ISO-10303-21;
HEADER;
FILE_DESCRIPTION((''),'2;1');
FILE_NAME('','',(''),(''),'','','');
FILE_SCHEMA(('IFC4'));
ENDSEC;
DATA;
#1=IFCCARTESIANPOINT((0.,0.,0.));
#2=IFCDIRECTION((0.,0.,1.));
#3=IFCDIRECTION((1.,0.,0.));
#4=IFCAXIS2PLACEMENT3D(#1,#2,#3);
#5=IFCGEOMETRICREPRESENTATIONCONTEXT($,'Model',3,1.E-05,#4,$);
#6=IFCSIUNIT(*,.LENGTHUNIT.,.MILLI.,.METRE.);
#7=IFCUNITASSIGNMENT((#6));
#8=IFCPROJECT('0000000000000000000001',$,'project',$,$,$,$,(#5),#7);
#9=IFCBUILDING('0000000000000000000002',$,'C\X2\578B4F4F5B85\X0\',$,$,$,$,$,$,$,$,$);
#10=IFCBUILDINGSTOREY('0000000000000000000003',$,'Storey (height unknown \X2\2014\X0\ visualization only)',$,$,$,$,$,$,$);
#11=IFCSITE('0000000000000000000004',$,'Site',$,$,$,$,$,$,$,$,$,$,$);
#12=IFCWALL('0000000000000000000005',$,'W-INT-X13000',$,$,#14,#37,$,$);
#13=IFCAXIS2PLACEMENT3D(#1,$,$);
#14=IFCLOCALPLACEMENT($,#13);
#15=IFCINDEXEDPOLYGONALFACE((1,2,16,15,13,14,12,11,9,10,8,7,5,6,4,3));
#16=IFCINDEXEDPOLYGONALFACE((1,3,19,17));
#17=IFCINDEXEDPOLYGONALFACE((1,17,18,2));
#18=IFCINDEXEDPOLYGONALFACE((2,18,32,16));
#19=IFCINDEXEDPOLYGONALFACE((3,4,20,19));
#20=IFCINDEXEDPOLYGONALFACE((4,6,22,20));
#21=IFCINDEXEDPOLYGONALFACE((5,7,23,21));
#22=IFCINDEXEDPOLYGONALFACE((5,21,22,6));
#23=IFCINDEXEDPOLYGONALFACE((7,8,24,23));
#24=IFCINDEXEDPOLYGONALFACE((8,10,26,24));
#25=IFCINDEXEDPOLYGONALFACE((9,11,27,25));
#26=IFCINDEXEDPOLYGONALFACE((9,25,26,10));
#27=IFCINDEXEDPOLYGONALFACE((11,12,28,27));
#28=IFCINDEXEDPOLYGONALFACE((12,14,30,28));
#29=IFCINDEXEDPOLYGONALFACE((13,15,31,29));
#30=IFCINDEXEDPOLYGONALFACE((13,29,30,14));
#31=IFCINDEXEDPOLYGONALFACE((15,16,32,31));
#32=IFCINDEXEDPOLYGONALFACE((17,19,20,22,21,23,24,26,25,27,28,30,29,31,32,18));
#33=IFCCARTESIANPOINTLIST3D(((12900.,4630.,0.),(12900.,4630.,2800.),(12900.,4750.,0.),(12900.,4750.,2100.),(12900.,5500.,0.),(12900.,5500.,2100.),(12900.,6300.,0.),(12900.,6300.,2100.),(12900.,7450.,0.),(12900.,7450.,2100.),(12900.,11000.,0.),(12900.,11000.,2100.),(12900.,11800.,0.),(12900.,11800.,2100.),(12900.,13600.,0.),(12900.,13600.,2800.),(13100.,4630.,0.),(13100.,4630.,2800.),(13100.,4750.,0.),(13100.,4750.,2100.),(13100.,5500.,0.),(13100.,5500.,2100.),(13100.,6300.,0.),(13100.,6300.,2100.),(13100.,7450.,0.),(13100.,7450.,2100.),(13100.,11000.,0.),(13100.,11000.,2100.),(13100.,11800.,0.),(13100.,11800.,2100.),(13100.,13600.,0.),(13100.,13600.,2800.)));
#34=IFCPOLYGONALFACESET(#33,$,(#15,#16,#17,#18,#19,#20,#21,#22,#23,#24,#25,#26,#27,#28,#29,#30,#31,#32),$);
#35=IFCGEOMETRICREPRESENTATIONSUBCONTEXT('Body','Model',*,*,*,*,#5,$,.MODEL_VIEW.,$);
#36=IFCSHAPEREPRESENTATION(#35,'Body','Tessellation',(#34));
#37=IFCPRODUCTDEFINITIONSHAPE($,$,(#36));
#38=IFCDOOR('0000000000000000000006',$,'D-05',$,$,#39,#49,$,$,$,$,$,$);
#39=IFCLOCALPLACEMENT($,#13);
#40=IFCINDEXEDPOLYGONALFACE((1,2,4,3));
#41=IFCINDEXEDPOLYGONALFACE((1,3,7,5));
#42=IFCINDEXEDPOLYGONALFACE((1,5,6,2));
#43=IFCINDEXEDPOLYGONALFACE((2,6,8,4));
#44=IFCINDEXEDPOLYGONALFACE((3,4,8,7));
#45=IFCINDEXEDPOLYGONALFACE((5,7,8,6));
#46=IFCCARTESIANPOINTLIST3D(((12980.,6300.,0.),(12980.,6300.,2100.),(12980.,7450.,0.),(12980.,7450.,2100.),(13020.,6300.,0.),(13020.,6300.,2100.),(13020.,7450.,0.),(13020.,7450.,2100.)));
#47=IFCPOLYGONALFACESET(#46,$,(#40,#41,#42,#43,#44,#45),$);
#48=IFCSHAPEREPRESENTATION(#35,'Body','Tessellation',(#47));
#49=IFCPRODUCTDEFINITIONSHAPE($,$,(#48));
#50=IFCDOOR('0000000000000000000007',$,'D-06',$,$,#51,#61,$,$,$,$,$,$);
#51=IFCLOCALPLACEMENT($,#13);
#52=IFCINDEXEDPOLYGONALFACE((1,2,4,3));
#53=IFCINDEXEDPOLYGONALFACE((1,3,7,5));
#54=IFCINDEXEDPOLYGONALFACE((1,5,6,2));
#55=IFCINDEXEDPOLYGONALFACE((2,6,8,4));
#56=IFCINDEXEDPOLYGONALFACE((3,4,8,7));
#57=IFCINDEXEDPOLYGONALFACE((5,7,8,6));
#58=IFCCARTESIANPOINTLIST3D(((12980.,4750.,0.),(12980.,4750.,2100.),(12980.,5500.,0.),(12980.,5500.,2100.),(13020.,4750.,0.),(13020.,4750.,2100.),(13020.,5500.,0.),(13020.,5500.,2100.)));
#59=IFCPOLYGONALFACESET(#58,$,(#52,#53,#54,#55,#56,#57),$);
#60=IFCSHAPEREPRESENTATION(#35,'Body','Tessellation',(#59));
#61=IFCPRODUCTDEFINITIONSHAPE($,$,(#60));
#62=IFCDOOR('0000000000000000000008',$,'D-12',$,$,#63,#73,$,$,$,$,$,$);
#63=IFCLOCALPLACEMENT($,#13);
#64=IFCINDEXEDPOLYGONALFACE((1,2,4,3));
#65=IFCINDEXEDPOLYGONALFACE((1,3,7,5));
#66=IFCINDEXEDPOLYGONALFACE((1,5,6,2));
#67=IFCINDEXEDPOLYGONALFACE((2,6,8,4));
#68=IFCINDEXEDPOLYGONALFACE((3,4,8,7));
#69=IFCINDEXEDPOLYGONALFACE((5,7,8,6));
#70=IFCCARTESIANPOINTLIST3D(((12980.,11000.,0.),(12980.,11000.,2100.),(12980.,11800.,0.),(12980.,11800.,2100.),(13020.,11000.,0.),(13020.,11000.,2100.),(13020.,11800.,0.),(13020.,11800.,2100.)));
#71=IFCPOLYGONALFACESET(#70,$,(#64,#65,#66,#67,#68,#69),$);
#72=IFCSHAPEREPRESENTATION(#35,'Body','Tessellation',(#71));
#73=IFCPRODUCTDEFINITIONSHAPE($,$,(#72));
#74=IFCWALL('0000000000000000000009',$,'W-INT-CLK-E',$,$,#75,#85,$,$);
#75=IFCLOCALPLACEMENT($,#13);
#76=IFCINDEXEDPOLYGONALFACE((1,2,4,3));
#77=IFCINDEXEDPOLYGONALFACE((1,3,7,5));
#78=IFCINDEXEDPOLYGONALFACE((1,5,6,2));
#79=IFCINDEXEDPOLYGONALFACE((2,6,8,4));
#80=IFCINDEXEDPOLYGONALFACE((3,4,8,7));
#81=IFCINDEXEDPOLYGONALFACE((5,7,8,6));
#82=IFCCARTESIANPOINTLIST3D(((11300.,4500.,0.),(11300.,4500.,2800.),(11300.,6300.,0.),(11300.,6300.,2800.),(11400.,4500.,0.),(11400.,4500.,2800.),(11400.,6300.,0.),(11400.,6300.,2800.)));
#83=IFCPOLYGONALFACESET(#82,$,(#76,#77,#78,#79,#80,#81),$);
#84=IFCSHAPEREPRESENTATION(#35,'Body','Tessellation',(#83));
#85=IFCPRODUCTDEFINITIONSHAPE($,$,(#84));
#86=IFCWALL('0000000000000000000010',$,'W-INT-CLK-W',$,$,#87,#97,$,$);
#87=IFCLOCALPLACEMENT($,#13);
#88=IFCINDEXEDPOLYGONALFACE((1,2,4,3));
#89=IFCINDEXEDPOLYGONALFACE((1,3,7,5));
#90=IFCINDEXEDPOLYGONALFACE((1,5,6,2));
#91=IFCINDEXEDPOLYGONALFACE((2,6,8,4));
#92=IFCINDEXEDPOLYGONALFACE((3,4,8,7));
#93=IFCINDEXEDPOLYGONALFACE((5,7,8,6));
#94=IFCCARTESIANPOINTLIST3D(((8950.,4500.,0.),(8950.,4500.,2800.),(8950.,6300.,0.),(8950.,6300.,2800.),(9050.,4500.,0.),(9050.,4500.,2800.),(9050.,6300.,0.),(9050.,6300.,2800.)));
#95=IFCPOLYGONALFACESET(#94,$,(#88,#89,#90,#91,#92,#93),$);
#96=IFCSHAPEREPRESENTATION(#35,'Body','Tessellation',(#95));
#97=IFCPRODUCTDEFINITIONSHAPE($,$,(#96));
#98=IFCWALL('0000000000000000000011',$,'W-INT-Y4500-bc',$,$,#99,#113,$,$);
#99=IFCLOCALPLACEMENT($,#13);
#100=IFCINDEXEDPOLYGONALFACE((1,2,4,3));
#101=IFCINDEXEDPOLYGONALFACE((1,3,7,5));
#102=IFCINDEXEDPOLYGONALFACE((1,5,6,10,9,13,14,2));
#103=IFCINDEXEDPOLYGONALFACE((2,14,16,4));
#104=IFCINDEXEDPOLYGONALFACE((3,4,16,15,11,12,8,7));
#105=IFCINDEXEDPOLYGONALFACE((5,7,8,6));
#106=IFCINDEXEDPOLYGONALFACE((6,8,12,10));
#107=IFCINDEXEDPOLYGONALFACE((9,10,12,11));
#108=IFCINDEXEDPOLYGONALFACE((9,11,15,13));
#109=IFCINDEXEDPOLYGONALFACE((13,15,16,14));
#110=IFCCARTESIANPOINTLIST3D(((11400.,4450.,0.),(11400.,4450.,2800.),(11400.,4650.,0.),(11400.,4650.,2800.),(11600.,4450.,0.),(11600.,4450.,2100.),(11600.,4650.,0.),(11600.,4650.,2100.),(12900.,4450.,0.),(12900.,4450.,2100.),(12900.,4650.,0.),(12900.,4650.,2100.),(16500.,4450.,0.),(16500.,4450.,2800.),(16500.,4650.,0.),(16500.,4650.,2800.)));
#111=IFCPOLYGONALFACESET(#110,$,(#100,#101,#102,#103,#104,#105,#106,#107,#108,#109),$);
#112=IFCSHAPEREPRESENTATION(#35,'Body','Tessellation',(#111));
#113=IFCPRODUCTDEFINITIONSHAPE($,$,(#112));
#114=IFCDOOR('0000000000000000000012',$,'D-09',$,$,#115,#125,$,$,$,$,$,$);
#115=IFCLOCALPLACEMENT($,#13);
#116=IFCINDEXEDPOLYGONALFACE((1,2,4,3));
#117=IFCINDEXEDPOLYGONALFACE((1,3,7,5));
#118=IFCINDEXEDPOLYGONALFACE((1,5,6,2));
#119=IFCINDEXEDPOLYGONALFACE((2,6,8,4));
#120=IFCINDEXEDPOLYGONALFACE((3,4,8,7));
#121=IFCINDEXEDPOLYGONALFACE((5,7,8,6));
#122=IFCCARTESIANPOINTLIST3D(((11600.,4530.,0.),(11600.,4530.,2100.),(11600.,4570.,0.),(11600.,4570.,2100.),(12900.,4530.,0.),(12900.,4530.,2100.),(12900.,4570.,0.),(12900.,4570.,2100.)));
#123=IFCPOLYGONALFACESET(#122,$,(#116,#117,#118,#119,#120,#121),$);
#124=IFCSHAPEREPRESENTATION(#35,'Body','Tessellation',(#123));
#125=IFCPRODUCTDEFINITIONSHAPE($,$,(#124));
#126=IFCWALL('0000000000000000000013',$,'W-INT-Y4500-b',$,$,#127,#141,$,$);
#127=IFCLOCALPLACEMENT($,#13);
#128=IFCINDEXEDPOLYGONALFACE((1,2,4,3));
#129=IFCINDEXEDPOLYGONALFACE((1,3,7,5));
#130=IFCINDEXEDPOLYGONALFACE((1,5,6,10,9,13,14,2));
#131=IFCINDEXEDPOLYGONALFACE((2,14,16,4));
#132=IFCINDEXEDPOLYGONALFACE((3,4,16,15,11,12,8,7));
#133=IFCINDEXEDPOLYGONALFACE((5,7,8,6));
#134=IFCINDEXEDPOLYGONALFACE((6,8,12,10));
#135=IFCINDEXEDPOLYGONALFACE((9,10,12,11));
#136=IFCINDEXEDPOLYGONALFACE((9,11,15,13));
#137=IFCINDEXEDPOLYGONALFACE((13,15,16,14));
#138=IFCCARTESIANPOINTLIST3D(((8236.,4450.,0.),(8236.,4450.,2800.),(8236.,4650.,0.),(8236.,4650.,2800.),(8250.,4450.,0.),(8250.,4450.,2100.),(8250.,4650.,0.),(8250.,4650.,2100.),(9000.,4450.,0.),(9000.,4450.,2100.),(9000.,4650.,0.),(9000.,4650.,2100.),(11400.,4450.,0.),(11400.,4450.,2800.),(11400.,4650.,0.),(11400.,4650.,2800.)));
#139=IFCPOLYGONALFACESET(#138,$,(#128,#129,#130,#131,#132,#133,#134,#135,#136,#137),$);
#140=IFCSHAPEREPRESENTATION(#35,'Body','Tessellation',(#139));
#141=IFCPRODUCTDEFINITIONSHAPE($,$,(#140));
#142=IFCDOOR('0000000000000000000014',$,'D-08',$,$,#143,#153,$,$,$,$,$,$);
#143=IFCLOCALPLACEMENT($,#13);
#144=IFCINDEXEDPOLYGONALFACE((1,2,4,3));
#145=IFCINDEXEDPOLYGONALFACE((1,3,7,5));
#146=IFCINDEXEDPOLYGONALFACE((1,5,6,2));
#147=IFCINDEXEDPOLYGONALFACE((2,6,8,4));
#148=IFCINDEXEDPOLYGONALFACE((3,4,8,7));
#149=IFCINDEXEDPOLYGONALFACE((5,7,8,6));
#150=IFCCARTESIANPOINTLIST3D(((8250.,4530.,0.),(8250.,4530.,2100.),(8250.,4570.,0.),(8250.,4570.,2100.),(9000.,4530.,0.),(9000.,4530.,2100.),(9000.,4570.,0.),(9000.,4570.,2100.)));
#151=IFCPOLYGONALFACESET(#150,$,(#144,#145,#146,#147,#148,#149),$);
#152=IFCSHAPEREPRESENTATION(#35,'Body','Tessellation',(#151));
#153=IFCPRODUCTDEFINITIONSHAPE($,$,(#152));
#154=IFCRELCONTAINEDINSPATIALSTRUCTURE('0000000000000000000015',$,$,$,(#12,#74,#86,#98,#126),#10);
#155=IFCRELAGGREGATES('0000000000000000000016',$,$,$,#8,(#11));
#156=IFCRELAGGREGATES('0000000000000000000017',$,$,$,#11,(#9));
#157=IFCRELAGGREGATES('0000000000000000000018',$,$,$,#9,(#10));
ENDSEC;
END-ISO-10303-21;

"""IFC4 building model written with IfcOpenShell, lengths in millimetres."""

from ifc_helpers import new_model, si_unit, frame, frame_2d, origin_with_axes, place, context, subcontext, project, spatial, rectangle, extrude, element, fill, save


model = new_model("IFC4")

# Units and contexts
model_context = context("Model", 3, precision=1e-05, world=origin_with_axes())
body_context = subcontext(model_context, "Body", "Model", "MODEL_VIEW")
ifc_project = project(units=[si_unit("LENGTHUNIT", "METRE", prefix="MILLI")], contexts=[model_context])

# Site, building, storey
site = spatial("IfcSite", under=ifc_project, Name="Site")
building = spatial("IfcBuilding", under=site, Name="C型住宅")
storey = spatial("IfcBuildingStorey", under=building, Name="Storey (height unknown — visualization only)")

# Wall, openings, doors
wall_1_placement = place(None, frame((12900.0, 4630.0, 0.0), z_axis=(0.0, 0.0, 1.0), x_axis=(1.0, 0.0, 0.0)))
wall_1 = element("IfcWall", 1, at=wall_1_placement, inside=storey, Name="W-INT-X13000", context=body_context, shape_type="SweptSolid", body=[
    extrude(rectangle(XDim=200.0, YDim=8970.0, at=frame_2d((100.0, 4485.0))), origin_with_axes(), (0.0, 0.0, 1.0), 2800.0),
])
opening_1_placement = place(wall_1_placement, frame((0.0, 1670.0, 0.0)))
opening_1 = element("IfcOpeningElement", 2, at=opening_1_placement, cuts=wall_1, context=body_context, shape_type="SweptSolid", body=[
    extrude(rectangle(XDim=200.0, YDim=1150.0, at=frame_2d((100.0, 575.0))), origin_with_axes(), (0.0, 0.0, 1.0), 2100.0),
])
opening_2_placement = place(wall_1_placement, frame((0.0, 120.0, 0.0)))
opening_2 = element("IfcOpeningElement", 3, at=opening_2_placement, cuts=wall_1, context=body_context, shape_type="SweptSolid", body=[
    extrude(rectangle(XDim=200.0, YDim=750.0, at=frame_2d((100.0, 375.0))), origin_with_axes(), (0.0, 0.0, 1.0), 2100.0),
])
opening_3_placement = place(wall_1_placement, frame((0.0, 6370.0, 0.0)))
opening_3 = element("IfcOpeningElement", 4, at=opening_3_placement, cuts=wall_1, context=body_context, shape_type="SweptSolid", body=[
    extrude(rectangle(XDim=200.0, YDim=800.0, at=frame_2d((100.0, 400.0))), origin_with_axes(), (0.0, 0.0, 1.0), 2100.0),
])
door_1_placement = place(wall_1_placement, frame((80.0, 1670.0, 0.0)))
door_1 = element("IfcDoor", 5, at=door_1_placement, Name="D-05", context=body_context, shape_type="SweptSolid", body=[
    extrude(rectangle(XDim=40.0, YDim=1150.0, at=frame_2d((20.0, 575.0))), origin_with_axes(), (0.0, 0.0, 1.0), 2100.0),
])
fill(opening_1, door_1)
door_2_placement = place(wall_1_placement, frame((80.0, 120.0, 0.0)))
door_2 = element("IfcDoor", 6, at=door_2_placement, Name="D-06", context=body_context, shape_type="SweptSolid", body=[
    extrude(rectangle(XDim=40.0, YDim=750.0, at=frame_2d((20.0, 375.0))), origin_with_axes(), (0.0, 0.0, 1.0), 2100.0),
])
fill(opening_2, door_2)
door_3_placement = place(wall_1_placement, frame((80.0, 6370.0, 0.0)))
door_3 = element("IfcDoor", 7, at=door_3_placement, Name="D-12", context=body_context, shape_type="SweptSolid", body=[
    extrude(rectangle(XDim=40.0, YDim=800.0, at=frame_2d((20.0, 400.0))), origin_with_axes(), (0.0, 0.0, 1.0), 2100.0),
])
fill(opening_3, door_3)

# Walls
for number, where, z_axis, x_axis, name in (
    (8, (11300.0, 4500.0, 0.0), (0.0, 0.0, 1.0), (1.0, 0.0, 0.0), "W-INT-CLK-E"),
    (9, (8950.0, 4500.0, 0.0), (0.0, 0.0, 1.0), (1.0, 0.0, 0.0), "W-INT-CLK-W"),
):
    element("IfcWall", number, at=place(None, frame(where, z_axis=z_axis, x_axis=x_axis)), inside=storey, Name=name, context=body_context, shape_type="SweptSolid", body=[
        extrude(rectangle(XDim=100.0, YDim=1800.0, at=frame_2d((50.0, 900.0))), origin_with_axes(), (0.0, 0.0, 1.0), 2800.0),
    ])

# Walls, openings, doors
wall_2_placement = place(None, frame((11400.0, 4450.0, 0.0), z_axis=(0.0, 0.0, 1.0), x_axis=(1.0, 0.0, 0.0)))
wall_2 = element("IfcWall", 10, at=wall_2_placement, inside=storey, Name="W-INT-Y4500-bc", context=body_context, shape_type="SweptSolid", body=[
    extrude(rectangle(XDim=5100.0, YDim=200.0, at=frame_2d((2550.0, 100.0))), origin_with_axes(), (0.0, 0.0, 1.0), 2800.0),
])
opening_4_placement = place(wall_2_placement, frame((200.0, 0.0, 0.0)))
opening_4 = element("IfcOpeningElement", 11, at=opening_4_placement, cuts=wall_2, context=body_context, shape_type="SweptSolid", body=[
    extrude(rectangle(XDim=1300.0, YDim=200.0, at=frame_2d((650.0, 100.0))), origin_with_axes(), (0.0, 0.0, 1.0), 2100.0),
])
door_4_placement = place(wall_2_placement, frame((200.0, 80.0, 0.0)))
door_4 = element("IfcDoor", 12, at=door_4_placement, Name="D-09", context=body_context, shape_type="SweptSolid", body=[
    extrude(rectangle(XDim=1300.0, YDim=40.0, at=frame_2d((650.0, 20.0))), origin_with_axes(), (0.0, 0.0, 1.0), 2100.0),
])
fill(opening_4, door_4)
wall_3_placement = place(None, frame((8236.0, 4450.0, 0.0), z_axis=(0.0, 0.0, 1.0), x_axis=(1.0, 0.0, 0.0)))
wall_3 = element("IfcWall", 13, at=wall_3_placement, inside=storey, Name="W-INT-Y4500-b", context=body_context, shape_type="SweptSolid", body=[
    extrude(rectangle(XDim=3164.0, YDim=200.0, at=frame_2d((1582.0, 100.0))), origin_with_axes(), (0.0, 0.0, 1.0), 2800.0),
])
opening_5_placement = place(wall_3_placement, frame((14.0, 0.0, 0.0)))
opening_5 = element("IfcOpeningElement", 14, at=opening_5_placement, cuts=wall_3, context=body_context, shape_type="SweptSolid", body=[
    extrude(rectangle(XDim=750.0, YDim=200.0, at=frame_2d((375.0, 100.0))), origin_with_axes(), (0.0, 0.0, 1.0), 2100.0),
])
door_5_placement = place(wall_3_placement, frame((14.0, 80.0, 0.0)))
door_5 = element("IfcDoor", 15, at=door_5_placement, Name="D-08", context=body_context, shape_type="SweptSolid", body=[
    extrude(rectangle(XDim=750.0, YDim=40.0, at=frame_2d((375.0, 20.0))), origin_with_axes(), (0.0, 0.0, 1.0), 2100.0),
])
fill(opening_5, door_5)

save(model, "model.ifc")
